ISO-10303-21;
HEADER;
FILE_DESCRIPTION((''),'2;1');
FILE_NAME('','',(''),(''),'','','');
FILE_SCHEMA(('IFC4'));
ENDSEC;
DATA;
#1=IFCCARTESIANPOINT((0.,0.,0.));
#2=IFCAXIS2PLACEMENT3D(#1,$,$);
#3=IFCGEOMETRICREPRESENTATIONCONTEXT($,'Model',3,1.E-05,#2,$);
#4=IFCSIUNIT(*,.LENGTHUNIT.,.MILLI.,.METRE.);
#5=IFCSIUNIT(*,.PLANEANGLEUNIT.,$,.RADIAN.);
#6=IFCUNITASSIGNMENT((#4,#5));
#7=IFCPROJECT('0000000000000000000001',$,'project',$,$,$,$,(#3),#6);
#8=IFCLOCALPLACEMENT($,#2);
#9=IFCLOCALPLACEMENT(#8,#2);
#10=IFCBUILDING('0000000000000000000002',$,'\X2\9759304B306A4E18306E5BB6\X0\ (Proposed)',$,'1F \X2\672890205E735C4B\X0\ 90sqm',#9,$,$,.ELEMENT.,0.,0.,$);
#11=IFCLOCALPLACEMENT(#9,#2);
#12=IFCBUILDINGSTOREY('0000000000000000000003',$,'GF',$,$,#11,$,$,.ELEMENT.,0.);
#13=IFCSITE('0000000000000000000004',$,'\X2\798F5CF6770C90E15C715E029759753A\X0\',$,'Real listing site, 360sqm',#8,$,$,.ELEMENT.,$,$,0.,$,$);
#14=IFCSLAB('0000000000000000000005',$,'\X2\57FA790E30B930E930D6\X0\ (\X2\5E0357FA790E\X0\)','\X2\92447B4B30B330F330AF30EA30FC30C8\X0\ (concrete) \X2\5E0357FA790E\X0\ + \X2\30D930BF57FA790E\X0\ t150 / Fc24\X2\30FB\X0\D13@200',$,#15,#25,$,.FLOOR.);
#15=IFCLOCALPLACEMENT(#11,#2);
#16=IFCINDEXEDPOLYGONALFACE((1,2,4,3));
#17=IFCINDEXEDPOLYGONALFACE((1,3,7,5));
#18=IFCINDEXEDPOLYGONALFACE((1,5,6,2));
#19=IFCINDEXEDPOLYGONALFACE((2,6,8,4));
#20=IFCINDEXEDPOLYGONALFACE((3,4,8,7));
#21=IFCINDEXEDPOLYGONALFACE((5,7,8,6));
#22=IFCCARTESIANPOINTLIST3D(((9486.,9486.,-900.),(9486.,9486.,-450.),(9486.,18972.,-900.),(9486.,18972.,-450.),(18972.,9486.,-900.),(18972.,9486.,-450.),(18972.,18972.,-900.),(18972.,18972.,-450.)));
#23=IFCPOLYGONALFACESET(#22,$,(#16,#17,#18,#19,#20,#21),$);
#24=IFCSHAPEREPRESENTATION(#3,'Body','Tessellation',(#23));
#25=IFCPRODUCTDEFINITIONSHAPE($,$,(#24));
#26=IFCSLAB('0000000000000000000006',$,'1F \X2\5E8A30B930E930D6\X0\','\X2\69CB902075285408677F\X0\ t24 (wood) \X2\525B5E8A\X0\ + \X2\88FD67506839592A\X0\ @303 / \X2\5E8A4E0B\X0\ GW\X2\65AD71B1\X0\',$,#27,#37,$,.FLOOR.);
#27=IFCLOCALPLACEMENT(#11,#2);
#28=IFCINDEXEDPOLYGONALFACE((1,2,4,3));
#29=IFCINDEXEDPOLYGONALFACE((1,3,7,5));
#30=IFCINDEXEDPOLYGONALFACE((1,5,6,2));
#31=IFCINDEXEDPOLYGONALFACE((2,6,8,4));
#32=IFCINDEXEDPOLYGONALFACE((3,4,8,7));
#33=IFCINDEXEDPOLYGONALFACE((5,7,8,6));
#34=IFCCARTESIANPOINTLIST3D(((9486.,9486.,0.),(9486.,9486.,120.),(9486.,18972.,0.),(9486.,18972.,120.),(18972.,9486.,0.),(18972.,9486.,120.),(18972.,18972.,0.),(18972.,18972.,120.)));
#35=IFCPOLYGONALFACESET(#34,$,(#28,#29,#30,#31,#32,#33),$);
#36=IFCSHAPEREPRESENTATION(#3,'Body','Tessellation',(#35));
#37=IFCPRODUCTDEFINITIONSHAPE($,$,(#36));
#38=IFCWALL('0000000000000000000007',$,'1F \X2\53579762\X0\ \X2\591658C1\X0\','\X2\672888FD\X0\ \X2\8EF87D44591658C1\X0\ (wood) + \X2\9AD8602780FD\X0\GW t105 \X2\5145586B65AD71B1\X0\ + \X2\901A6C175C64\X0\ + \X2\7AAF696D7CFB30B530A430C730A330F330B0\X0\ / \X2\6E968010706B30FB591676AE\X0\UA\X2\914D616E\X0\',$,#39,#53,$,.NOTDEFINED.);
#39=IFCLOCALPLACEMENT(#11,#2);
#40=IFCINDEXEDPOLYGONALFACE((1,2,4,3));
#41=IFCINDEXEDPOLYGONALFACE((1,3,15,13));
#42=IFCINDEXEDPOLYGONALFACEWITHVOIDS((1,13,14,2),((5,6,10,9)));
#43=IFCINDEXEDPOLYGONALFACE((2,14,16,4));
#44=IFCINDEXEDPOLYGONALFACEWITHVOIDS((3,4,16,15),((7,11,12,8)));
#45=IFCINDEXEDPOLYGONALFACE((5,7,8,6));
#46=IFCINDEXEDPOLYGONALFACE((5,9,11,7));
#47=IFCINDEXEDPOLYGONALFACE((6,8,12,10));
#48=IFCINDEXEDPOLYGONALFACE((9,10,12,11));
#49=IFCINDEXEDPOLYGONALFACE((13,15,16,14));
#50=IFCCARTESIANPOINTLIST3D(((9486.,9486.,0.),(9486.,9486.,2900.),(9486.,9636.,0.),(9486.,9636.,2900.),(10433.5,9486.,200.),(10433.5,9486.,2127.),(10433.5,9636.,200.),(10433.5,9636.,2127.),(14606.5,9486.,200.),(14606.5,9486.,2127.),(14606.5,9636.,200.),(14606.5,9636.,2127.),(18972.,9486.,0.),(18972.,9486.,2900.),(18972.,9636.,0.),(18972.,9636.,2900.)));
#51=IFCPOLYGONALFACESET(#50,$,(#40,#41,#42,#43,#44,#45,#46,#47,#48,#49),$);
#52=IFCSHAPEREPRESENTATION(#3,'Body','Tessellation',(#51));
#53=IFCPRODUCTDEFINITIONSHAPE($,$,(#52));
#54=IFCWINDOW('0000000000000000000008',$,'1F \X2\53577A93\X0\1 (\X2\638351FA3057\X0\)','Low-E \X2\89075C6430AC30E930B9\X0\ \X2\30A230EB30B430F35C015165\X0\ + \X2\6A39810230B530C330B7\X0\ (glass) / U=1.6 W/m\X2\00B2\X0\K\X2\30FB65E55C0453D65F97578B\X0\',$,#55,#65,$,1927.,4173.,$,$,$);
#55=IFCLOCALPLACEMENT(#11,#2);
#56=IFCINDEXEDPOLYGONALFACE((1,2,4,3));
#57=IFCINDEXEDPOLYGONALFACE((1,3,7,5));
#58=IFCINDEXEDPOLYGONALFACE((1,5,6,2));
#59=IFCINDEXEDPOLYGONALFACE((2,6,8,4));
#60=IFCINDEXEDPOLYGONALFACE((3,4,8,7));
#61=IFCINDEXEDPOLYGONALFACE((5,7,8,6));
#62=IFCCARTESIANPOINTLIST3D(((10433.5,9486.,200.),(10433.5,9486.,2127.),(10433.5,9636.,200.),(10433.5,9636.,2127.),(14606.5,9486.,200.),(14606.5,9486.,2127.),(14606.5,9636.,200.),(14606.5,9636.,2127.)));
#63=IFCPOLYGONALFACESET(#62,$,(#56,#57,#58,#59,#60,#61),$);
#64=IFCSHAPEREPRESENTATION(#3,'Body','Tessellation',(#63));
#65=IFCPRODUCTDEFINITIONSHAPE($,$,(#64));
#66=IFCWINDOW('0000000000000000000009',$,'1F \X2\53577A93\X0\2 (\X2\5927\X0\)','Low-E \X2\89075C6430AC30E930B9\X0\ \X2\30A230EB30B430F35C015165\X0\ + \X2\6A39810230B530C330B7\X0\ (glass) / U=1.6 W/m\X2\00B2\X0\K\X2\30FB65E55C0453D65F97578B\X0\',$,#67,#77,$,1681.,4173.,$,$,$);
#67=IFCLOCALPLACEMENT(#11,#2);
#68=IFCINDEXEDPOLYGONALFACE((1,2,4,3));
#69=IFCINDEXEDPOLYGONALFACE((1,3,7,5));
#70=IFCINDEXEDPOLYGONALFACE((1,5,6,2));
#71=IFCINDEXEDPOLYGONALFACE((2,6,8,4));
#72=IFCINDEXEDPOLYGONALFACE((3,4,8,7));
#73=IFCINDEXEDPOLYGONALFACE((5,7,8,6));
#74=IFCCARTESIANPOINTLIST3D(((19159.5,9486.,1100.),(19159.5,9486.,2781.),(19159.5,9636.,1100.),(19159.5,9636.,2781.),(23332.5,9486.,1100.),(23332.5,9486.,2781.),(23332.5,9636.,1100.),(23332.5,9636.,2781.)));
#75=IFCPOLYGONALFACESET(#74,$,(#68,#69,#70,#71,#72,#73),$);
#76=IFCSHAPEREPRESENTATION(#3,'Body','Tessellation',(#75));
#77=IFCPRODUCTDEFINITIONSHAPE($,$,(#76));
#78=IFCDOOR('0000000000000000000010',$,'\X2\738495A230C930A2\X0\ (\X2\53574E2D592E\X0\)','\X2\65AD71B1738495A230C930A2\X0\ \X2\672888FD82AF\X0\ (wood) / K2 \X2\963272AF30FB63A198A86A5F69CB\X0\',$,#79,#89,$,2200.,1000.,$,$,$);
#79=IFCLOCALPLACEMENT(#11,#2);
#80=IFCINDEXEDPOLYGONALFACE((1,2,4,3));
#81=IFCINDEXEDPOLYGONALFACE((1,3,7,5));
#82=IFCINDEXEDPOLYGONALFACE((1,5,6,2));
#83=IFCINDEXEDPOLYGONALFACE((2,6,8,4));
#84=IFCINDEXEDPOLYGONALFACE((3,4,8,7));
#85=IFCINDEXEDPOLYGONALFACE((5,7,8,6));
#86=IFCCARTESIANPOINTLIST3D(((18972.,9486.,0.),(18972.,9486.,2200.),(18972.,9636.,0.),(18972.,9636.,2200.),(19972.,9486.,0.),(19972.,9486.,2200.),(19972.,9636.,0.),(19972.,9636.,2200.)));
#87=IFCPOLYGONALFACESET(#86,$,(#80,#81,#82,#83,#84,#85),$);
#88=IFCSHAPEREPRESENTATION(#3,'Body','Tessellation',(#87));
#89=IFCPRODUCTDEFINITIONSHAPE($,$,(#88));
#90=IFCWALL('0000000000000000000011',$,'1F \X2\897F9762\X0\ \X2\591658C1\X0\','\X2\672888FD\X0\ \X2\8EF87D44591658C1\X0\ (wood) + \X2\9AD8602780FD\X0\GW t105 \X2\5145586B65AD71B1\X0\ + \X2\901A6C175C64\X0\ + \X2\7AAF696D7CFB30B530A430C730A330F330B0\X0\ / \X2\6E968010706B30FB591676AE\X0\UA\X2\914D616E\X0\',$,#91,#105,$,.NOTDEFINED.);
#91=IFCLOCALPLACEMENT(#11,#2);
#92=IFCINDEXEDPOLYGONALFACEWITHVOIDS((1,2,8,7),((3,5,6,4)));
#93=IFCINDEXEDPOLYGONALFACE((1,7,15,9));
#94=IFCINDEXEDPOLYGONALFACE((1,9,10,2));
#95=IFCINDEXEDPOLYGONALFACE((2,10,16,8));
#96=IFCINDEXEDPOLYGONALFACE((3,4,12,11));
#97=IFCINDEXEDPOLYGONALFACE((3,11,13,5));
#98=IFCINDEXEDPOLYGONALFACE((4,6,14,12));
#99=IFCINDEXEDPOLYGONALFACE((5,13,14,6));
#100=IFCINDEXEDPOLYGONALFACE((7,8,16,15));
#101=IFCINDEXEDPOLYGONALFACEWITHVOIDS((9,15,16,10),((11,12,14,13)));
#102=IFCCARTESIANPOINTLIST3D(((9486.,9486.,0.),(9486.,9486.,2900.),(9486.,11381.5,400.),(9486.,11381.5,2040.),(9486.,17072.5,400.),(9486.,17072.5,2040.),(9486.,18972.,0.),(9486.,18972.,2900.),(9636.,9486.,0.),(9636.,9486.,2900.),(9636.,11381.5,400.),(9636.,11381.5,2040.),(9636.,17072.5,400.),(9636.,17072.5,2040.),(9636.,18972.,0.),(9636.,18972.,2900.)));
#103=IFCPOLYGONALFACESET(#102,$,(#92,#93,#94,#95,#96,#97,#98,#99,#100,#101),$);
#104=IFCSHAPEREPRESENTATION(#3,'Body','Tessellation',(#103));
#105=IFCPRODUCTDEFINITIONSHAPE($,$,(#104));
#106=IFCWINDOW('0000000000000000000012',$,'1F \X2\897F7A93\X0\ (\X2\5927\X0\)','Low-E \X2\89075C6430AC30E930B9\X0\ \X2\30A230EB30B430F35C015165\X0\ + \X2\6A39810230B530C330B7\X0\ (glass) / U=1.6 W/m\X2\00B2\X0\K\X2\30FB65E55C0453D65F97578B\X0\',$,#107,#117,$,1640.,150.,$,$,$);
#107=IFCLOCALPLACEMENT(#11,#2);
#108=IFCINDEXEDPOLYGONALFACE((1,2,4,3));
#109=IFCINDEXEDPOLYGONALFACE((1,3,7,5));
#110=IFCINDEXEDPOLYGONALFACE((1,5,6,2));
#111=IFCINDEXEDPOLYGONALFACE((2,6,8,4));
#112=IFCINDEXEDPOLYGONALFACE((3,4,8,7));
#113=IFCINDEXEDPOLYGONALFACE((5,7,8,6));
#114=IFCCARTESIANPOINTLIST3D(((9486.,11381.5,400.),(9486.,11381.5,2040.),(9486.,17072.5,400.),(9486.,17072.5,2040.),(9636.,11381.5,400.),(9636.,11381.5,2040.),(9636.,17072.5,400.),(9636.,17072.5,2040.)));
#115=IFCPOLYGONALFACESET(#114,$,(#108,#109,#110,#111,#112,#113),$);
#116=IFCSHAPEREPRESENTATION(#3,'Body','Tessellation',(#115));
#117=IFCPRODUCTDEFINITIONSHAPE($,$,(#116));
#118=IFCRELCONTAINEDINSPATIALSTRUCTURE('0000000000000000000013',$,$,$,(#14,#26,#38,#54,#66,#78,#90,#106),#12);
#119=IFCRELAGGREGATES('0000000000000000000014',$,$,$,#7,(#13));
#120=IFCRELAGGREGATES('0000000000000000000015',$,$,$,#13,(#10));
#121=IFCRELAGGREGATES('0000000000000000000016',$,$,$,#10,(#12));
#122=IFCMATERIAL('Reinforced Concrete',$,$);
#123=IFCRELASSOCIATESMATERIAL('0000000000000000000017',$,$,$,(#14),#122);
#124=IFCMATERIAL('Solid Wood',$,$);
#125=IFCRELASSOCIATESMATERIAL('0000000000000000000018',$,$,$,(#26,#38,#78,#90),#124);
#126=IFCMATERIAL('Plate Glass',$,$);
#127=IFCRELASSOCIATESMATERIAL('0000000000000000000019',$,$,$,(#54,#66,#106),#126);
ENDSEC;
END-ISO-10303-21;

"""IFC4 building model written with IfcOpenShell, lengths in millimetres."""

from ifc_helpers import new_model, si_unit, frame, frame_2d, origin, place, context, project, spatial, rectangle, extrude, material, element, fill, save


model = new_model("IFC4")

# Units and contexts
model_context = context("Model", 3, precision=1e-05, world=origin())
ifc_project = project(units=[si_unit("LENGTHUNIT", "METRE", prefix="MILLI"), si_unit("PLANEANGLEUNIT", "RADIAN")], contexts=[model_context])

# Site, building, storey
site_placement = place(None, origin())
site = spatial("IfcSite", under=ifc_project, at=site_placement, Name="福島県郡山市静町", ObjectType="Real listing site, 360sqm", CompositionType="ELEMENT", RefElevation=0.0)
building_placement = place(site_placement, origin())
building = spatial("IfcBuilding", under=site, at=building_placement, Name="静かな丘の家 (Proposed)", ObjectType="1F 木造平屋 90sqm", CompositionType="ELEMENT", ElevationOfRefHeight=0.0, ElevationOfTerrain=0.0)
storey_placement = place(building_placement, origin())
storey = spatial("IfcBuildingStorey", under=building, at=storey_placement, Name="GF", CompositionType="ELEMENT", Elevation=0.0)

# Slabs
ifc_material_1 = material(Name="Reinforced Concrete")
slab_1_placement = place(storey_placement, frame((4743.0, 4743.0, -450.0)))
element("IfcSlab", 1, at=slab_1_placement, inside=storey, material=ifc_material_1, Name="基礎スラブ (布基礎)", Description="鉄筋コンクリート (concrete) 布基礎 + ベタ基礎 t150 / Fc24・D13@200", PredefinedType="FLOOR", context=model_context, shape_type="SweptSolid", body=[
    extrude(rectangle(XDim=9486.0, YDim=9486.0, at=frame_2d((4743.0, 4743.0))), frame((4743.0, 4743.0, -450.0)), (0.0, 0.0, 1.0), 450.0),
])
ifc_material_2 = material(Name="Solid Wood")
slab_2_placement = place(storey_placement, frame((4743.0, 4743.0, 0.0)))
element("IfcSlab", 2, at=slab_2_placement, inside=storey, material=ifc_material_2, Name="1F 床スラブ", Description="構造用合板 t24 (wood) 剛床 + 製材根太 @303 / 床下 GW断熱", PredefinedType="FLOOR", context=model_context, shape_type="SweptSolid", body=[
    extrude(rectangle(XDim=9486.0, YDim=9486.0, at=frame_2d((4743.0, 4743.0))), frame((4743.0, 4743.0, 0.0)), (0.0, 0.0, 1.0), 120.0),
])

# Wall, openings, windows, door
wall_1_placement = place(storey_placement, frame((4743.0, 4743.0, 0.0)))
wall_1 = element("IfcWall", 3, at=wall_1_placement, inside=storey, material=ifc_material_2, Name="1F 南面 外壁", Description="木製 軸組外壁 (wood) + 高性能GW t105 充填断熱 + 通気層 + 窯業系サイディング / 準耐火・外皮UA配慮", PredefinedType="NOTDEFINED", context=model_context, shape_type="SweptSolid", body=[
    extrude(rectangle(XDim=9486.0, YDim=150.0, at=frame_2d((4743.0, 75.0))), frame((4743.0, 4743.0, 0.0)), (0.0, 0.0, 1.0), 2900.0),
])
opening_1_placement = place(storey_placement, frame((5217.0, 4743.0, 100.0)))
opening_1 = element("IfcOpeningElement", 4, at=opening_1_placement, cuts=wall_1, PredefinedType="NOTDEFINED", context=model_context, shape_type="SweptSolid", body=[
    extrude(rectangle(XDim=4173.0, YDim=150.0, at=frame_2d((2086.0, 75.0))), frame((5217.0, 4743.0, 100.0)), (0.0, 0.0, 1.0), 1927.0),
])
opening_2_placement = place(storey_placement, frame((9580.0, 4743.0, 550.0)))
opening_2 = element("IfcOpeningElement", 5, at=opening_2_placement, cuts=wall_1, PredefinedType="NOTDEFINED", context=model_context, shape_type="SweptSolid", body=[
    extrude(rectangle(XDim=4173.0, YDim=150.0, at=frame_2d((2086.0, 75.0))), frame((9580.0, 4743.0, 550.0)), (0.0, 0.0, 1.0), 1681.0),
])
opening_3_placement = place(storey_placement, frame((9486.0, 4743.0, 0.0)))
opening_3 = element("IfcOpeningElement", 6, at=opening_3_placement, cuts=wall_1, PredefinedType="NOTDEFINED", context=model_context, shape_type="SweptSolid", body=[
    extrude(rectangle(XDim=1000.0, YDim=150.0, at=frame_2d((500.0, 75.0))), frame((9486.0, 4743.0, 0.0)), (0.0, 0.0, 1.0), 2200.0),
])
ifc_material_3 = material(Name="Plate Glass")
window_1_placement = place(storey_placement, frame((5217.0, 4743.0, 100.0)))
window_1 = element("IfcWindow", 7, at=window_1_placement, inside=storey, material=ifc_material_3, Name="1F 南窓1 (掃出し)", Description="Low-E 複層ガラス アルゴン封入 + 樹脂サッシ (glass) / U=1.6 W/m²K・日射取得型", OverallHeight=1927.0, OverallWidth=4173.0, context=model_context, shape_type="SweptSolid", body=[
    extrude(rectangle(XDim=4173.0, YDim=150.0, at=frame_2d((2086.0, 75.0))), frame((5217.0, 4743.0, 100.0)), (0.0, 0.0, 1.0), 1927.0),
])
fill(opening_1, window_1)
window_2_placement = place(storey_placement, frame((9580.0, 4743.0, 550.0)))
window_2 = element("IfcWindow", 8, at=window_2_placement, inside=storey, material=ifc_material_3, Name="1F 南窓2 (大)", Description="Low-E 複層ガラス アルゴン封入 + 樹脂サッシ (glass) / U=1.6 W/m²K・日射取得型", OverallHeight=1681.0, OverallWidth=4173.0, context=model_context, shape_type="SweptSolid", body=[
    extrude(rectangle(XDim=4173.0, YDim=150.0, at=frame_2d((2086.0, 75.0))), frame((9580.0, 4743.0, 550.0)), (0.0, 0.0, 1.0), 1681.0),
])
fill(opening_2, window_2)
door_placement = place(storey_placement, frame((9486.0, 4743.0, 0.0)))
door = element("IfcDoor", 9, at=door_placement, inside=storey, material=ifc_material_2, Name="玄関ドア (南中央)", Description="断熱玄関ドア 木製芯 (wood) / K2 防犯・採風機構", OverallHeight=2200.0, OverallWidth=1000.0, context=model_context, shape_type="SweptSolid", body=[
    extrude(rectangle(XDim=1000.0, YDim=150.0, at=frame_2d((500.0, 75.0))), frame((9486.0, 4743.0, 0.0)), (0.0, 0.0, 1.0), 2200.0),
])
fill(opening_3, door)

# Wall, opening, window
wall_2_placement = place(storey_placement, frame((4743.0, 4743.0, 0.0)))
wall_2 = element("IfcWall", 10, at=wall_2_placement, inside=storey, material=ifc_material_2, Name="1F 西面 外壁", Description="木製 軸組外壁 (wood) + 高性能GW t105 充填断熱 + 通気層 + 窯業系サイディング / 準耐火・外皮UA配慮", PredefinedType="NOTDEFINED", context=model_context, shape_type="SweptSolid", body=[
    extrude(rectangle(XDim=150.0, YDim=9486.0, at=frame_2d((75.0, 4743.0))), frame((4743.0, 4743.0, 0.0)), (0.0, 0.0, 1.0), 2900.0),
])
opening_4_placement = place(storey_placement, frame((4743.0, 5691.0, 200.0)))
opening_4 = element("IfcOpeningElement", 11, at=opening_4_placement, cuts=wall_2, PredefinedType="NOTDEFINED", context=model_context, shape_type="SweptSolid", body=[
    extrude(rectangle(XDim=150.0, YDim=5691.0, at=frame_2d((75.0, 2845.0))), frame((4743.0, 5691.0, 200.0)), (0.0, 0.0, 1.0), 1640.0),
])
window_3_placement = place(storey_placement, frame((4743.0, 5691.0, 200.0)))
window_3 = element("IfcWindow", 12, at=window_3_placement, inside=storey, material=ifc_material_3, Name="1F 西窓 (大)", Description="Low-E 複層ガラス アルゴン封入 + 樹脂サッシ (glass) / U=1.6 W/m²K・日射取得型", OverallHeight=1640.0, OverallWidth=150.0, context=model_context, shape_type="SweptSolid", body=[
    extrude(rectangle(XDim=150.0, YDim=5691.0, at=frame_2d((75.0, 2845.0))), frame((4743.0, 5691.0, 200.0)), (0.0, 0.0, 1.0), 1640.0),
])
fill(opening_4, window_3)

save(model, "model.ifc")
